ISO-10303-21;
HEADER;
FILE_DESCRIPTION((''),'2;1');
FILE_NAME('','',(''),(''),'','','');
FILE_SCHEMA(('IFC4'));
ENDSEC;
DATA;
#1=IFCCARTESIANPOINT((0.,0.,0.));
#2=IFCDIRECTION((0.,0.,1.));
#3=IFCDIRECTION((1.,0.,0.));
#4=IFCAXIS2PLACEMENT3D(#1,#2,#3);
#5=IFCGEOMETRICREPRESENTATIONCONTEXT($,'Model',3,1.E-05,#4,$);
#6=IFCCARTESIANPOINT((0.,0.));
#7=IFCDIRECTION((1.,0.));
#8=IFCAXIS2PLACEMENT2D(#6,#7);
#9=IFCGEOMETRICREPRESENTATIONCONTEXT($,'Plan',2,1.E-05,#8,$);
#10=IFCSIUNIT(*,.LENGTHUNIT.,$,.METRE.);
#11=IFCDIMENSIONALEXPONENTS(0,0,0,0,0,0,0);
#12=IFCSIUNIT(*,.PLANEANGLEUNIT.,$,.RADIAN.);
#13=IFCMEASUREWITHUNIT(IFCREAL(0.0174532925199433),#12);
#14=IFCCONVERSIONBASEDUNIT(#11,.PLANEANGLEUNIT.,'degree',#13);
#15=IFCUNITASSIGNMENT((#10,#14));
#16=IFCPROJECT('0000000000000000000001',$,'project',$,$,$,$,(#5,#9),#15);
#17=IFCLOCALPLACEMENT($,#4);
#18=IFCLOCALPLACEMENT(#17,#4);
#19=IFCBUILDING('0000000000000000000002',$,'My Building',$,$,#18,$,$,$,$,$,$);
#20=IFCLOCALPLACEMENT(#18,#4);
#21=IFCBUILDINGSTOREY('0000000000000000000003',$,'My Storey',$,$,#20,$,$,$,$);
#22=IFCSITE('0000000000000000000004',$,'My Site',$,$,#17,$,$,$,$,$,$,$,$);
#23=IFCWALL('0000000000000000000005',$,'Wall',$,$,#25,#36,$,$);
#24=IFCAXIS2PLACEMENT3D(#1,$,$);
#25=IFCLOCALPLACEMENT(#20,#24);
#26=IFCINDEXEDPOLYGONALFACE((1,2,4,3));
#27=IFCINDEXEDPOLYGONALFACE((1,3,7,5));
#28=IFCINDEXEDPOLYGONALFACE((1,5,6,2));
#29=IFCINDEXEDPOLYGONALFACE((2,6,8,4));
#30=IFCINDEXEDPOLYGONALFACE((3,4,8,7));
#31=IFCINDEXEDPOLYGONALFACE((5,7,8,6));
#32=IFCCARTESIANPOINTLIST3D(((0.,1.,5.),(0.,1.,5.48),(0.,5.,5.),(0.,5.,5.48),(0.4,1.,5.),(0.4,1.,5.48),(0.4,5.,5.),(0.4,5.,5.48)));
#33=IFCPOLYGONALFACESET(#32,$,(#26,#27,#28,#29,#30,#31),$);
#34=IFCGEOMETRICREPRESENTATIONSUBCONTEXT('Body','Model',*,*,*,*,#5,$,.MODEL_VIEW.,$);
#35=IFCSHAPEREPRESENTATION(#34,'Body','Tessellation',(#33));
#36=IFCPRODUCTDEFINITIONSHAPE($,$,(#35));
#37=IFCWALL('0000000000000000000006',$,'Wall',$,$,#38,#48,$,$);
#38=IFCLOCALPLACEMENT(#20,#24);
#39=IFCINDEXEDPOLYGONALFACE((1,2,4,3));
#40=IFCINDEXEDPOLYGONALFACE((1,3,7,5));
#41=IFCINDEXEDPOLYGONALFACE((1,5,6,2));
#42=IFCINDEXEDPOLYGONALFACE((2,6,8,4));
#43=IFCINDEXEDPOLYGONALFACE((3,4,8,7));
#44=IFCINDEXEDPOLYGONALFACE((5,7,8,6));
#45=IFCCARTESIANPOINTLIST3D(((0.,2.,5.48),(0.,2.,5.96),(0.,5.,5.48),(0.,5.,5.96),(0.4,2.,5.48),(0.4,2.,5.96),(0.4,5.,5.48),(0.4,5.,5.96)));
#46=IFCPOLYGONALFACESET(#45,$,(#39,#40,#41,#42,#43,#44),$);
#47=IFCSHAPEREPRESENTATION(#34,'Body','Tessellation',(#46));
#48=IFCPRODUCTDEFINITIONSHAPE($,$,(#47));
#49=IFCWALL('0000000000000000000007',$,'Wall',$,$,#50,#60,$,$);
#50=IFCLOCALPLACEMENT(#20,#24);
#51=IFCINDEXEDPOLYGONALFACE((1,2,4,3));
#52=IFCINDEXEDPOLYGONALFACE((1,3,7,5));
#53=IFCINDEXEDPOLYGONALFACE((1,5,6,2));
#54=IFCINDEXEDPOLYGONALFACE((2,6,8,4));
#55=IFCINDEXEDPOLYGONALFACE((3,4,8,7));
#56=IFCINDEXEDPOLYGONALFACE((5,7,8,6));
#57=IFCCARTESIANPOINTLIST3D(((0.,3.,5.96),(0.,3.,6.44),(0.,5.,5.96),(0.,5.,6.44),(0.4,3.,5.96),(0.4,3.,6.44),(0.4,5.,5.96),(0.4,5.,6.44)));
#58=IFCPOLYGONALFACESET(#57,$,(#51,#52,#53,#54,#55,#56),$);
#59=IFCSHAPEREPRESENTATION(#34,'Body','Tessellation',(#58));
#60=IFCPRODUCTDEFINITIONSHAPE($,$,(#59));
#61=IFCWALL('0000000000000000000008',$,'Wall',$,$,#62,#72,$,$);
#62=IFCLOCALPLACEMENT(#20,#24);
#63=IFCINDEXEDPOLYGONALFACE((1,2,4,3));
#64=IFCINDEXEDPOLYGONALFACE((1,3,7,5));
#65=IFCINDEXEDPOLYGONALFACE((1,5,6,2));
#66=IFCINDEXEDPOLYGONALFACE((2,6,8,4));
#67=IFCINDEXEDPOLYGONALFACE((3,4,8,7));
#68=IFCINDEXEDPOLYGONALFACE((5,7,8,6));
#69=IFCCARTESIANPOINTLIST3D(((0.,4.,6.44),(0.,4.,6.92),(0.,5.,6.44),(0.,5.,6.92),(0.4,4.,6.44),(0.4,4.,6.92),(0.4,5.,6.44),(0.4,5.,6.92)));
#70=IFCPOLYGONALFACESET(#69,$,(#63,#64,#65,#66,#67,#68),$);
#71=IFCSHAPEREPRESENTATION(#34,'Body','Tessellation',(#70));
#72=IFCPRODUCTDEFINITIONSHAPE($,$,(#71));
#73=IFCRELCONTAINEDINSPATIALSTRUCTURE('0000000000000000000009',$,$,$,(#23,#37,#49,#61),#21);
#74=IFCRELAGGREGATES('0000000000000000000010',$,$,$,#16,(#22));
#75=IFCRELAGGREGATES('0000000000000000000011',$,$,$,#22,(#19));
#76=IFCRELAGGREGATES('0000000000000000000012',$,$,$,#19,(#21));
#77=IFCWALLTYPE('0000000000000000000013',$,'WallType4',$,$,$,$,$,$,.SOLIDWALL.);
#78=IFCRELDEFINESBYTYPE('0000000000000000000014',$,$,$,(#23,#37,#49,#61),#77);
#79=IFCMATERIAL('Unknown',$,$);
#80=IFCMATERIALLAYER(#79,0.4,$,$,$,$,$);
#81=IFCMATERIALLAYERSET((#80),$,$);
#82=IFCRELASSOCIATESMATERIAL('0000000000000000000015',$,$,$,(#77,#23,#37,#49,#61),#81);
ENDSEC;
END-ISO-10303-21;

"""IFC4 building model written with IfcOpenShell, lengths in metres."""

from ifc_helpers import new_model, entity, si_unit, converted_unit, frame, origin_with_axes, origin_2d_with_axis, place, context, subcontext, project, spatial, indexed_curve, outline, extrude, material, layer, layer_set, layer_usage, type_object, element, save


model = new_model("IFC4")

# Units and contexts
model_context = context("Model", 3, precision=1e-05, world=origin_with_axes())
plan_context = context("Plan", 2, precision=1e-05, world=origin_2d_with_axis())
body_context_1 = subcontext(model_context, "Body", "Model", "MODEL_VIEW")
ifc_project = project(units=[si_unit("LENGTHUNIT", "METRE"), converted_unit("PLANEANGLEUNIT", "degree", entity("IfcReal", 0.0174532925199433), si_unit("PLANEANGLEUNIT", "RADIAN"), dimensions=[0, 0, 0, 0, 0, 0, 0])], contexts=[model_context, plan_context])

# Site, building, storey
site_placement = place(None, origin_with_axes())
site = spatial("IfcSite", under=ifc_project, at=site_placement, Name="My Site")
building_placement = place(site_placement, origin_with_axes())
building = spatial("IfcBuilding", under=site, at=building_placement, Name="My Building")
storey_placement = place(building_placement, origin_with_axes())
storey = spatial("IfcBuildingStorey", under=building, at=storey_placement, Name="My Storey")

# Shared definitions
ifc_material = material(Name="Unknown")

# Shared definitions
ifc_layer_1 = layer(ifc_material, 0.4)
ifc_layer_set_1 = layer_set([ifc_layer_1])
wall_type_1 = type_object("IfcWallType", Name="WallType4", PredefinedType="SOLIDWALL", material=ifc_layer_set_1)

# Walls
ifc_layer_usage_1 = layer_usage(ifc_layer_set_1, "AXIS2", "POSITIVE", 0.0)
wall_1_placement = place(storey_placement, frame((0.4, 1.0, 5.0), z_axis=(0.0, 0.0, 1.0), x_axis=(0.0, 1.0, 0.0)))
element("IfcWall", 1, at=wall_1_placement, inside=storey, type_object=wall_type_1, material=ifc_layer_usage_1, Name="Wall", context=body_context_1, shape_type="SweptSolid", body=[
    extrude(outline(indexed_curve([(0.0, 0.0), (0.0, 0.4), (4.0, 0.4), (4.0, 0.0), (0.0, 0.0)], self_intersect=False)), origin_with_axes(), (0.0, 0.0, 1.0), 0.48),
])
ifc_layer_usage_2 = layer_usage(ifc_layer_set_1, "AXIS2", "POSITIVE", 0.0)
wall_2_placement = place(storey_placement, frame((0.4, 2.0, 5.48), z_axis=(0.0, 0.0, 1.0), x_axis=(0.0, 1.0, 0.0)))
element("IfcWall", 2, at=wall_2_placement, inside=storey, type_object=wall_type_1, material=ifc_layer_usage_2, Name="Wall", context=body_context_1, shape_type="SweptSolid", body=[
    extrude(outline(indexed_curve([(0.0, 0.0), (0.0, 0.4), (3.0, 0.4), (3.0, 0.0), (0.0, 0.0)], self_intersect=False)), origin_with_axes(), (0.0, 0.0, 1.0), 0.48),
])
ifc_layer_usage_3 = layer_usage(ifc_layer_set_1, "AXIS2", "POSITIVE", 0.0)
wall_3_placement = place(storey_placement, frame((0.4, 3.0, 5.96), z_axis=(0.0, 0.0, 1.0), x_axis=(0.0, 1.0, 0.0)))
element("IfcWall", 3, at=wall_3_placement, inside=storey, type_object=wall_type_1, material=ifc_layer_usage_3, Name="Wall", context=body_context_1, shape_type="SweptSolid", body=[
    extrude(outline(indexed_curve([(0.0, 0.0), (0.0, 0.4), (2.0, 0.4), (2.0, 0.0), (0.0, 0.0)], self_intersect=False)), origin_with_axes(), (0.0, 0.0, 1.0), 0.48),
])
ifc_layer_usage_4 = layer_usage(ifc_layer_set_1, "AXIS2", "POSITIVE", 0.0)
wall_4_placement = place(storey_placement, frame((0.4, 4.0, 6.44), z_axis=(0.0, 0.0, 1.0), x_axis=(0.0, 1.0, 0.0)))
element("IfcWall", 4, at=wall_4_placement, inside=storey, type_object=wall_type_1, material=ifc_layer_usage_4, Name="Wall", context=body_context_1, shape_type="SweptSolid", body=[
    extrude(outline(indexed_curve([(0.0, 0.0), (0.0, 0.4), (1.0, 0.4), (1.0, 0.0), (0.0, 0.0)], self_intersect=False)), origin_with_axes(), (0.0, 0.0, 1.0), 0.48),
])

save(model, "model.ifc")
